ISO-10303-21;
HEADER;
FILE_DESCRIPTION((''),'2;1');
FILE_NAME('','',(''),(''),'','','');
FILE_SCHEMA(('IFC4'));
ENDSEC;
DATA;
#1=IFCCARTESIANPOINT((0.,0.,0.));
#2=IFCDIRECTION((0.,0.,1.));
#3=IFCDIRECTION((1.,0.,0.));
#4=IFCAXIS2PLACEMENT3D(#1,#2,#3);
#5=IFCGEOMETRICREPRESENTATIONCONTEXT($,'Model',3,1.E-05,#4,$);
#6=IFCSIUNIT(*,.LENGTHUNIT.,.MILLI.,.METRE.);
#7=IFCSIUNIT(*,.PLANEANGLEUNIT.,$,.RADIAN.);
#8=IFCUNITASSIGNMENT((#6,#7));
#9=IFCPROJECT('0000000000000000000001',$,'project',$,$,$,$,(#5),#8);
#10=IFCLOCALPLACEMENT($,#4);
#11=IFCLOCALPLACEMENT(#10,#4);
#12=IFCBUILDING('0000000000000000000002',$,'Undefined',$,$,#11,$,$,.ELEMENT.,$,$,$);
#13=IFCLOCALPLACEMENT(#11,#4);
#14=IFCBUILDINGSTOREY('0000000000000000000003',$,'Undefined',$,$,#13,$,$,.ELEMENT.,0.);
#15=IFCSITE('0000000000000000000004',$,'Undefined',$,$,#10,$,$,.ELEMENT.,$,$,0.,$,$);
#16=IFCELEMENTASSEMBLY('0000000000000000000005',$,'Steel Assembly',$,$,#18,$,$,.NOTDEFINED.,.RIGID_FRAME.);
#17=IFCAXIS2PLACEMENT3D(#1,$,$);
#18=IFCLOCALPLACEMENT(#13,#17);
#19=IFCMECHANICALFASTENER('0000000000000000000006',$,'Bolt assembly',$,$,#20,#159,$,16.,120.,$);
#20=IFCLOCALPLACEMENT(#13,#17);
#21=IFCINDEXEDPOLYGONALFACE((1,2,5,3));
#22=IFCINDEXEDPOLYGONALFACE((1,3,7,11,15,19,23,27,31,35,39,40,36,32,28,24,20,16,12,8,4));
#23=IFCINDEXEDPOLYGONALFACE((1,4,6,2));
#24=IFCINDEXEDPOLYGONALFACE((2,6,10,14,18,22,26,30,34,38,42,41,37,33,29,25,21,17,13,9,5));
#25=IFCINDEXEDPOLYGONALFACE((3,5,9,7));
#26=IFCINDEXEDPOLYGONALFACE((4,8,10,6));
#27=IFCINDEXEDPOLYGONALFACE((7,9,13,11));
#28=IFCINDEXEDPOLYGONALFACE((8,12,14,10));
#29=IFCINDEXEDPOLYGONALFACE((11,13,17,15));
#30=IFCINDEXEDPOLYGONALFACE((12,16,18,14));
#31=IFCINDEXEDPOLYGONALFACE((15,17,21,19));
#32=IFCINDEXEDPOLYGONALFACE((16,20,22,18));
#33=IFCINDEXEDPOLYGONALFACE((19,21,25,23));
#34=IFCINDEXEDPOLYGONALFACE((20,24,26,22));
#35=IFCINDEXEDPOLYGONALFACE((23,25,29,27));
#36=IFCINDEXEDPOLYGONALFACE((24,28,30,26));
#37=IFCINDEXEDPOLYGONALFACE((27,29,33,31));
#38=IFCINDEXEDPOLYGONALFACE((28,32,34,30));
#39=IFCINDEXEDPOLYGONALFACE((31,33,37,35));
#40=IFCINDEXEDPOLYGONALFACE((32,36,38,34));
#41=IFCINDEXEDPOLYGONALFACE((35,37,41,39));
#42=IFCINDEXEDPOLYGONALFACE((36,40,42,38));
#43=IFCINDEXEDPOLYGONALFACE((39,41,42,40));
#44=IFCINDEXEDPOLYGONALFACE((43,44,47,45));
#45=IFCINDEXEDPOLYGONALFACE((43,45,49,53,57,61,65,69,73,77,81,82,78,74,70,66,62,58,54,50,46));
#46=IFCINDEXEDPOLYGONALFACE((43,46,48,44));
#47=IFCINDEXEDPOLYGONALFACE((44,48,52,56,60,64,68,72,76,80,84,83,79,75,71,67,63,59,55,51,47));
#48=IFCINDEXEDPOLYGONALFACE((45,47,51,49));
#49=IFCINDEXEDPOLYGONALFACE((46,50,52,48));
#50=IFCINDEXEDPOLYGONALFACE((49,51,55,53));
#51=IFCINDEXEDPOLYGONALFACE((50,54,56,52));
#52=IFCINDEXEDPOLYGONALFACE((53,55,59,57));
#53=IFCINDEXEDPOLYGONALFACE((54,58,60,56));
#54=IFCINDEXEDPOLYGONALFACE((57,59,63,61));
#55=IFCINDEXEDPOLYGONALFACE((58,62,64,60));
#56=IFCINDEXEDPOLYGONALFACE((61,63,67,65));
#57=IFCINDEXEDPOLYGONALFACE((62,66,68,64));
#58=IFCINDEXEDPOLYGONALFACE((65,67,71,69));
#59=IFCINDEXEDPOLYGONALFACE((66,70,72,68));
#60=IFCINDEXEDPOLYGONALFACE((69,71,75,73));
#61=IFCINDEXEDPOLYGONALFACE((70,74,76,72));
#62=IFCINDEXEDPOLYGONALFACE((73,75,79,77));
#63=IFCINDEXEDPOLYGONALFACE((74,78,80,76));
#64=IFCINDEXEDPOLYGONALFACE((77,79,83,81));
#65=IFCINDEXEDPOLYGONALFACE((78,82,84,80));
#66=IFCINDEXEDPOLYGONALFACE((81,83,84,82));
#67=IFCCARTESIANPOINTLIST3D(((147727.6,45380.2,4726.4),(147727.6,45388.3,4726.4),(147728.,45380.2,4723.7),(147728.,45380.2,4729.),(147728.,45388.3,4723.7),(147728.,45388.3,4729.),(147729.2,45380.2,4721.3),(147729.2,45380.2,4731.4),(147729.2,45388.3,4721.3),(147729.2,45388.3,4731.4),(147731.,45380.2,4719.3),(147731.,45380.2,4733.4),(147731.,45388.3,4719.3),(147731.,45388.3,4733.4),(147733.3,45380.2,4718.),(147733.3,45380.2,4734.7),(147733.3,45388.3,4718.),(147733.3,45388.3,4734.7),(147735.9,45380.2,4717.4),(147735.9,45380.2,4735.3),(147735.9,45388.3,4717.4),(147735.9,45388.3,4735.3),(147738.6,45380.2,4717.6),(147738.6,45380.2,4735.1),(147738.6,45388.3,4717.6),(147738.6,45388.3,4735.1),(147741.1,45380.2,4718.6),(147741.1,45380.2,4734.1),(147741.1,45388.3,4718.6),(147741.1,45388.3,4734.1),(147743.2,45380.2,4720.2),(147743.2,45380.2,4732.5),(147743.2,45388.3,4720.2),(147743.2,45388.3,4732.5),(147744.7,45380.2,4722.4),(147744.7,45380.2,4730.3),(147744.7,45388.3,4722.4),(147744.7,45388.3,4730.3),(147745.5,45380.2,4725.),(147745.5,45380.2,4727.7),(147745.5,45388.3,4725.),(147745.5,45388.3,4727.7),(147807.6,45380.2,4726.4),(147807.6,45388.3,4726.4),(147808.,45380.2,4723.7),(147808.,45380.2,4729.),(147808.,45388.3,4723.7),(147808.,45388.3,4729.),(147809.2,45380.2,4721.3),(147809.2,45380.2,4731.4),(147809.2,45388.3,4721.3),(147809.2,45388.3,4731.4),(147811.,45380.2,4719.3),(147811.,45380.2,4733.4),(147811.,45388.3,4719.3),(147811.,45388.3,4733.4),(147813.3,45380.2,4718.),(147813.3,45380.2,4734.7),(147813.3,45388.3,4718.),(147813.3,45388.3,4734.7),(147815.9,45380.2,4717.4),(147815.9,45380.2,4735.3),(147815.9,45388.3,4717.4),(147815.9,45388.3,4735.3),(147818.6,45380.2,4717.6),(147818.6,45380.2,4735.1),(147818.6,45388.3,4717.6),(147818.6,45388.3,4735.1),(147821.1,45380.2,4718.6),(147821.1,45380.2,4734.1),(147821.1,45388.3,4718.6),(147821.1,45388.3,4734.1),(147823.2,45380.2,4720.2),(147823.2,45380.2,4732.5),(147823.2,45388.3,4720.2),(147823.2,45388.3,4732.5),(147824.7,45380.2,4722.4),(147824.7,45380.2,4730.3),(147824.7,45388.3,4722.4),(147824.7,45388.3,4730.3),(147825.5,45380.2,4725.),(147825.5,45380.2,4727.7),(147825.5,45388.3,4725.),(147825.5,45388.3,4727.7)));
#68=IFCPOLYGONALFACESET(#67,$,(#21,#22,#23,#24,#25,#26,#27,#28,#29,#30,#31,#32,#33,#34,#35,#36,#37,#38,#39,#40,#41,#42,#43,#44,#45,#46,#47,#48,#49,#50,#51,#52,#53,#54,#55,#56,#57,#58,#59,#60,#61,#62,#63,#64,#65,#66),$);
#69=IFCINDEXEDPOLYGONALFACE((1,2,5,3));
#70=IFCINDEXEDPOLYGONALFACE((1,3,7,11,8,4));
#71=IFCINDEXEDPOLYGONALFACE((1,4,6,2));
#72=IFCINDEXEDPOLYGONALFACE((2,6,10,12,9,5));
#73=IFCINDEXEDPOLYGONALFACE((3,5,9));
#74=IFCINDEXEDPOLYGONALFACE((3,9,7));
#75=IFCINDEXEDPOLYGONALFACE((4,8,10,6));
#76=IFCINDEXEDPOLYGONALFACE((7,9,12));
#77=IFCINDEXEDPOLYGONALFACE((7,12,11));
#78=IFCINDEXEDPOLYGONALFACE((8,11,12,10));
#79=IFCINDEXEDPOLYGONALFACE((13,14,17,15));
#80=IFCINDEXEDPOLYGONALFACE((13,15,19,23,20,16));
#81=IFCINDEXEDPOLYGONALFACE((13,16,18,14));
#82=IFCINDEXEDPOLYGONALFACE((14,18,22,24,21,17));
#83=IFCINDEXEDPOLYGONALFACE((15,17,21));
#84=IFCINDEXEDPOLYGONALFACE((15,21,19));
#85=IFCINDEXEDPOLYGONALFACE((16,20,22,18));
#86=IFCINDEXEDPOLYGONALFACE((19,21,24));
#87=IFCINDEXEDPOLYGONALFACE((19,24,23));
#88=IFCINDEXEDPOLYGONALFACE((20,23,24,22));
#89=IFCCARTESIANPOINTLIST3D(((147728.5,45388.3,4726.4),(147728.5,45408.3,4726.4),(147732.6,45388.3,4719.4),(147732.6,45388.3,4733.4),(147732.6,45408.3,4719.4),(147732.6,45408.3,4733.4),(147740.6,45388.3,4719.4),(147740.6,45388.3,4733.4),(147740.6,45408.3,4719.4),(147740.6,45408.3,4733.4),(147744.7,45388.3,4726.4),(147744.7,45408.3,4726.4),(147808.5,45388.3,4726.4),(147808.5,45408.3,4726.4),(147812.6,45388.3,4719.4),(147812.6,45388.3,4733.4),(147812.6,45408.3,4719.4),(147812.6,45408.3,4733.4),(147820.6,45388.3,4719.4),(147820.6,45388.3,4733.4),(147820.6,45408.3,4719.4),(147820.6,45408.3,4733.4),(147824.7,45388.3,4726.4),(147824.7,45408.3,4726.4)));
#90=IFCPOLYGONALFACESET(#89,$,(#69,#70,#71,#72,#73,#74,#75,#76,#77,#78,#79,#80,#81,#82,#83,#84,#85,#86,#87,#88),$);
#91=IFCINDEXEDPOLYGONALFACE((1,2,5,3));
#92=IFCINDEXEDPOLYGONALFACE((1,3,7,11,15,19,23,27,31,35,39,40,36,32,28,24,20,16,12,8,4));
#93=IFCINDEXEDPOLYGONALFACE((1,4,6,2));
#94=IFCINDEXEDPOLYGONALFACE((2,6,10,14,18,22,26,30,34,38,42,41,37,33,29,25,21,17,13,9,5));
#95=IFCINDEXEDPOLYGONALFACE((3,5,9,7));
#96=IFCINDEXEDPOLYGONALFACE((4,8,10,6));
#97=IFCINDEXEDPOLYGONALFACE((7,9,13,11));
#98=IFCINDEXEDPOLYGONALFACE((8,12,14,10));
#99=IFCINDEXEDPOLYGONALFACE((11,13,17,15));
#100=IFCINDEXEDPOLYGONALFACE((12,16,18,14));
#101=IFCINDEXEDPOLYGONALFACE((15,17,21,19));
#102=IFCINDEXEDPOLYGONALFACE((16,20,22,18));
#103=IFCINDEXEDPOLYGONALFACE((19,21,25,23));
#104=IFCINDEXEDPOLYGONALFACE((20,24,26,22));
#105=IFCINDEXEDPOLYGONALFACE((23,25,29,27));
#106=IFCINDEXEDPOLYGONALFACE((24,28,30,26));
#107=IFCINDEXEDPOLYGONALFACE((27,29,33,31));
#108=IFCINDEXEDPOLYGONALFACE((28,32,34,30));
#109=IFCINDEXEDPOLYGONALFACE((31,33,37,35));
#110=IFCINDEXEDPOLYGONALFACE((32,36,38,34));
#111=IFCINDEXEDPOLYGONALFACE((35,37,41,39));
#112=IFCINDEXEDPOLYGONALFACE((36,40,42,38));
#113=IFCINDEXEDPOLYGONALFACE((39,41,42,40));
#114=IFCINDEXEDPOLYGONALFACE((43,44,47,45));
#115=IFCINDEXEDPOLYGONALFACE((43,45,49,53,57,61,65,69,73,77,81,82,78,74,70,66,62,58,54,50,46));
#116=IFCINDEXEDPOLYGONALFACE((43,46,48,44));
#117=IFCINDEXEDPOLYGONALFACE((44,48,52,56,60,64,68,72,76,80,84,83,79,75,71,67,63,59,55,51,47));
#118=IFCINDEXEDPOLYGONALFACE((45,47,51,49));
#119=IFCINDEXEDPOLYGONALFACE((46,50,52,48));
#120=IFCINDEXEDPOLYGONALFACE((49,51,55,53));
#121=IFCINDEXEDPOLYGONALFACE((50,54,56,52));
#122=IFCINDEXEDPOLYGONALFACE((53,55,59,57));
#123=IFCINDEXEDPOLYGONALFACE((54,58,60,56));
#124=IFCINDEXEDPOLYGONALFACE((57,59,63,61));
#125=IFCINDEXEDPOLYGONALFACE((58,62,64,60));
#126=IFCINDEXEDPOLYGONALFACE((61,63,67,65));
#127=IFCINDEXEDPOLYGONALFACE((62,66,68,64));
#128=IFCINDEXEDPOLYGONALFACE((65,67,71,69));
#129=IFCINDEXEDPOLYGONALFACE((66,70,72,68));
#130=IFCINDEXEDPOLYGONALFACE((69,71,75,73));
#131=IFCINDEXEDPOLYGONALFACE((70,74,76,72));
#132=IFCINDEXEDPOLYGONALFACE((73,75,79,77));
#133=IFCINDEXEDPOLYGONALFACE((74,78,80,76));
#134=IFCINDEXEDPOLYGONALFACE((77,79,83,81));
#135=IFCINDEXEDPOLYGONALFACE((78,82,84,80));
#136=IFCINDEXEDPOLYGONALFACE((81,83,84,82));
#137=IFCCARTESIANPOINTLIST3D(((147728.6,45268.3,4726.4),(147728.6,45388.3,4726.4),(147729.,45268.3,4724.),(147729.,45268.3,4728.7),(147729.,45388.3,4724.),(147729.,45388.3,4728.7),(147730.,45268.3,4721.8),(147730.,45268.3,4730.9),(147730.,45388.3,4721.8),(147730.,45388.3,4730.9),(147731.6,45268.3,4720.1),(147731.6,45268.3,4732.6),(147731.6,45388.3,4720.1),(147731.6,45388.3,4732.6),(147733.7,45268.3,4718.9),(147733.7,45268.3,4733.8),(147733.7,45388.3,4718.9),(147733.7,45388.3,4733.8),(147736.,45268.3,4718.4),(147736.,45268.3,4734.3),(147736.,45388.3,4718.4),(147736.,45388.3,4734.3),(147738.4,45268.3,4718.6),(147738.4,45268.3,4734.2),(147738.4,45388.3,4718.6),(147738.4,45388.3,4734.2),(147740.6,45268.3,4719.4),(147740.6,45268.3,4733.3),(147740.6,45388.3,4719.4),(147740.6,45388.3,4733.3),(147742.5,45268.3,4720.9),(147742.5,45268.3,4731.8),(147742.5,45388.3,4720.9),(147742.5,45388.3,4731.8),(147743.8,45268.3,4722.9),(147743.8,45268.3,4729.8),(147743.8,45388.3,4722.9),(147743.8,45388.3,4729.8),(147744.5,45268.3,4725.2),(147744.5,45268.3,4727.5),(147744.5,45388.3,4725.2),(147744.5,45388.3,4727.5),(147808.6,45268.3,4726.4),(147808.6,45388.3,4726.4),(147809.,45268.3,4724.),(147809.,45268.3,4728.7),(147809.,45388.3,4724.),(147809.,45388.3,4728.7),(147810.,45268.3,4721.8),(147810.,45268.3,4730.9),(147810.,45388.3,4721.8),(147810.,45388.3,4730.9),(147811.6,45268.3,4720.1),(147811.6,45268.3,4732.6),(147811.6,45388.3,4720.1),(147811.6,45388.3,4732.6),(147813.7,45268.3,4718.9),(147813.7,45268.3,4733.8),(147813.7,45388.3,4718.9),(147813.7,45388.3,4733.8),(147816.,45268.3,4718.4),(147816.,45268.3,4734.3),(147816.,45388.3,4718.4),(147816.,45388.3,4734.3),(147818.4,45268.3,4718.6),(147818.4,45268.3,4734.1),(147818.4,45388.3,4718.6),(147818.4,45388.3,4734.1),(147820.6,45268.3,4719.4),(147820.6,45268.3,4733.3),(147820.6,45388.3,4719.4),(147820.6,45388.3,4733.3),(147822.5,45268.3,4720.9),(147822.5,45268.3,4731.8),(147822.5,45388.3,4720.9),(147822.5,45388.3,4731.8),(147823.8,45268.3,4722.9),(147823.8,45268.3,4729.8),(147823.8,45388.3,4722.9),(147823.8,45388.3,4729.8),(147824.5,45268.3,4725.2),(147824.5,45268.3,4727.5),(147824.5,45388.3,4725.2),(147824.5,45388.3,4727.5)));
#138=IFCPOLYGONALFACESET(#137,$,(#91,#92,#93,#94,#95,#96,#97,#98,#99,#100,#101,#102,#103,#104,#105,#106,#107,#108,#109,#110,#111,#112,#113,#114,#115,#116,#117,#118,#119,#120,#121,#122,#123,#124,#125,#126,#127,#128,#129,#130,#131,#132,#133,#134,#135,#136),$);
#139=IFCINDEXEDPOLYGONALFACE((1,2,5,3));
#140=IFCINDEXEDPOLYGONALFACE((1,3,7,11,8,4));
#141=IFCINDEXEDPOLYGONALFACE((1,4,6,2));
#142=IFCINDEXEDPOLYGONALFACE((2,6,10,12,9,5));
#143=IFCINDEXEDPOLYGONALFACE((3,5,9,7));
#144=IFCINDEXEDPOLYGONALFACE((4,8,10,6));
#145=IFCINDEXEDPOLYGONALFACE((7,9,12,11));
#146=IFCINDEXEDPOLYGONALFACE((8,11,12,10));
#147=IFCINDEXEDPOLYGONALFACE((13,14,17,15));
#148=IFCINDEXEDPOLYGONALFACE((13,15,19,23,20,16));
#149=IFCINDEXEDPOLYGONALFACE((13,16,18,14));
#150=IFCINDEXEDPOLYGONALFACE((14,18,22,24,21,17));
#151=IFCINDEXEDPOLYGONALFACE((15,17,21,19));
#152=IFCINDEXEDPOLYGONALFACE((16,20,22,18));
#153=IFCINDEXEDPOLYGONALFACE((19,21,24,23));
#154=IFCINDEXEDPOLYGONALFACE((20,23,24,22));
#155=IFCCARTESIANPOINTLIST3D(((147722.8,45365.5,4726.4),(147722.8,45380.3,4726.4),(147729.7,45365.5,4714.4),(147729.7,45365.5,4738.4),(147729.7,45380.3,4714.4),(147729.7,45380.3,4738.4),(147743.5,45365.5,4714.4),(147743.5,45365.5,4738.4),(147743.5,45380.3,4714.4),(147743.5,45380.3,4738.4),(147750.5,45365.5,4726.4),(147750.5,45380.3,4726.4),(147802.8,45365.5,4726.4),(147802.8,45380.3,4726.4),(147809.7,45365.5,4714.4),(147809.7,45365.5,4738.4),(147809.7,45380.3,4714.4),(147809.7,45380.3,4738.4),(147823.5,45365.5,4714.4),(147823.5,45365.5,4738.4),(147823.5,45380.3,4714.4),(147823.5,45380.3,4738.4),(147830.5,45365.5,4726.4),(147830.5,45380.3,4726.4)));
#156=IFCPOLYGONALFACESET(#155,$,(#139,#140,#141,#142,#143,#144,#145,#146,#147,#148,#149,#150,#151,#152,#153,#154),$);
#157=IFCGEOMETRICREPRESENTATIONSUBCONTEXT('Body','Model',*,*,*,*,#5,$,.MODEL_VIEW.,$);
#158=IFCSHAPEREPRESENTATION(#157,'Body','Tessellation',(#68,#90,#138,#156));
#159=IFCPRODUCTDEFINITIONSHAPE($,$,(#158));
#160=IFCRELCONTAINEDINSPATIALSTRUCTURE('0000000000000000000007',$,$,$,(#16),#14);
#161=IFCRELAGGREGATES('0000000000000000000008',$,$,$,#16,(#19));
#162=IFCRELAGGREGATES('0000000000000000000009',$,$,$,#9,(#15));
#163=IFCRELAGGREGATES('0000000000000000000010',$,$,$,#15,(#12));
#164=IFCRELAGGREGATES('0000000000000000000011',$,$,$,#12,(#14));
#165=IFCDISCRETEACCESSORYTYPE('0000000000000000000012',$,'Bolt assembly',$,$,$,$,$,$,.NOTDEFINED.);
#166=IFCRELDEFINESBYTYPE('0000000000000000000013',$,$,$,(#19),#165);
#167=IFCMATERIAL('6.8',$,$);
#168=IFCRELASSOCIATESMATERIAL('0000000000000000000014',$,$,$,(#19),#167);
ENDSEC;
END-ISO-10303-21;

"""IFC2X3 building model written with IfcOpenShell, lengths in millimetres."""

from ifc_helpers import new_model, si_unit, frame, origin_with_axes, origin_2d_with_axis, place, context, subcontext, project, spatial, polyline, circle, outline, extrude, source, transform, mapped, material, type_object, element, aggregate, save


model = new_model("IFC2X3")

# Units and contexts
model_context = context("Model", 3, precision=1e-05, world=origin_with_axes())
body_context = subcontext(model_context, "Body", "Model", "MODEL_VIEW")
ifc_project = project(units=[si_unit("LENGTHUNIT", "METRE", prefix="MILLI"), si_unit("PLANEANGLEUNIT", "RADIAN")], contexts=[model_context])

# Site, building, storey
site_placement = place(None, origin_with_axes())
site = spatial("IfcSite", under=ifc_project, at=site_placement, Name="Undefined", CompositionType="ELEMENT", RefElevation=0.0)
building_placement = place(site_placement, origin_with_axes())
building = spatial("IfcBuilding", under=site, at=building_placement, Name="Undefined", CompositionType="ELEMENT")
storey_placement = place(building_placement, origin_with_axes())
storey = spatial("IfcBuildingStorey", under=building, at=storey_placement, Name="Undefined", CompositionType="ELEMENT", Elevation=0.0)

# Element assembly
assembly_1_placement = place(storey_placement, origin_with_axes())
assembly_1 = element("IfcElementAssembly", 1, at=assembly_1_placement, inside=storey, Name="Steel Assembly", AssemblyPlace="NOTDEFINED", PredefinedType="RIGID_FRAME")

# Shared definitions
discrete_accessory_type_1 = type_object("IfcDiscreteAccessoryType", Name="Bolt assembly")

# Mechanical fastener
ifc_material_1 = material(Name="6.8")
shared_shape_1 = source(origin_with_axes(), body_context, "Body", "SweptSolid", [
    extrude(circle(Radius=9.0, at=origin_2d_with_axis()), frame((0.0, -8.0, 0.0), z_axis=(0.0, 1.0, 0.0), x_axis=(1.0, 0.0, 0.0)), (0.0, 0.0, 1.0), 8.1),
    extrude(outline(polyline([(8.1, 0.0), (4.0, 7.0), (-4.0, 7.0), (-8.1, 0.0), (-4.0, -7.0), (4.0, -7.0), (8.1, 0.0)])), frame((0.0, -28.0, 0.0), z_axis=(0.0, 1.0, 0.0), x_axis=(1.0, 0.0, 0.0)), (0.0, 0.0, 1.0), 20.0),
    extrude(circle(Radius=8.0, at=origin_2d_with_axis()), frame((0.0, -8.0, 0.0), z_axis=(0.0, 1.0, 0.0), x_axis=(1.0, 0.0, 0.0)), (0.0, 0.0, 1.0), 120.0),
    extrude(outline(polyline([(13.9, 0.0), (6.9, 12.0), (-6.9, 12.0), (-13.9, 0.0), (-6.9, -12.0), (6.9, -12.0), (13.9, 0.0)])), frame((0.0, 0.0, 0.0), z_axis=(0.0, 1.0, 0.0), x_axis=(1.0, 0.0, 0.0)), (0.0, 0.0, 1.0), 14.8),
])
mechanical_fastener_1_placement = place(assembly_1_placement, frame((147816.6, 45380.3, 4726.4), z_axis=(0.00001, 0.0, 1.0), x_axis=(-1.0, 0.0, 0.00001)))
mechanical_fastener_1 = element("IfcMechanicalFastener", 2, at=mechanical_fastener_1_placement, type_object=discrete_accessory_type_1, material=ifc_material_1, Name="Bolt assembly", NominalDiameter=16.0, NominalLength=120.0, context=body_context, shape_type="MappedRepresentation", body=[
    mapped(shared_shape_1, transform((0.0, 0.0, 0.0))),
    mapped(shared_shape_1, transform((80.0, 0.0, 0.0))),
])

aggregate(assembly_1, [mechanical_fastener_1])

save(model, "model.ifc")
